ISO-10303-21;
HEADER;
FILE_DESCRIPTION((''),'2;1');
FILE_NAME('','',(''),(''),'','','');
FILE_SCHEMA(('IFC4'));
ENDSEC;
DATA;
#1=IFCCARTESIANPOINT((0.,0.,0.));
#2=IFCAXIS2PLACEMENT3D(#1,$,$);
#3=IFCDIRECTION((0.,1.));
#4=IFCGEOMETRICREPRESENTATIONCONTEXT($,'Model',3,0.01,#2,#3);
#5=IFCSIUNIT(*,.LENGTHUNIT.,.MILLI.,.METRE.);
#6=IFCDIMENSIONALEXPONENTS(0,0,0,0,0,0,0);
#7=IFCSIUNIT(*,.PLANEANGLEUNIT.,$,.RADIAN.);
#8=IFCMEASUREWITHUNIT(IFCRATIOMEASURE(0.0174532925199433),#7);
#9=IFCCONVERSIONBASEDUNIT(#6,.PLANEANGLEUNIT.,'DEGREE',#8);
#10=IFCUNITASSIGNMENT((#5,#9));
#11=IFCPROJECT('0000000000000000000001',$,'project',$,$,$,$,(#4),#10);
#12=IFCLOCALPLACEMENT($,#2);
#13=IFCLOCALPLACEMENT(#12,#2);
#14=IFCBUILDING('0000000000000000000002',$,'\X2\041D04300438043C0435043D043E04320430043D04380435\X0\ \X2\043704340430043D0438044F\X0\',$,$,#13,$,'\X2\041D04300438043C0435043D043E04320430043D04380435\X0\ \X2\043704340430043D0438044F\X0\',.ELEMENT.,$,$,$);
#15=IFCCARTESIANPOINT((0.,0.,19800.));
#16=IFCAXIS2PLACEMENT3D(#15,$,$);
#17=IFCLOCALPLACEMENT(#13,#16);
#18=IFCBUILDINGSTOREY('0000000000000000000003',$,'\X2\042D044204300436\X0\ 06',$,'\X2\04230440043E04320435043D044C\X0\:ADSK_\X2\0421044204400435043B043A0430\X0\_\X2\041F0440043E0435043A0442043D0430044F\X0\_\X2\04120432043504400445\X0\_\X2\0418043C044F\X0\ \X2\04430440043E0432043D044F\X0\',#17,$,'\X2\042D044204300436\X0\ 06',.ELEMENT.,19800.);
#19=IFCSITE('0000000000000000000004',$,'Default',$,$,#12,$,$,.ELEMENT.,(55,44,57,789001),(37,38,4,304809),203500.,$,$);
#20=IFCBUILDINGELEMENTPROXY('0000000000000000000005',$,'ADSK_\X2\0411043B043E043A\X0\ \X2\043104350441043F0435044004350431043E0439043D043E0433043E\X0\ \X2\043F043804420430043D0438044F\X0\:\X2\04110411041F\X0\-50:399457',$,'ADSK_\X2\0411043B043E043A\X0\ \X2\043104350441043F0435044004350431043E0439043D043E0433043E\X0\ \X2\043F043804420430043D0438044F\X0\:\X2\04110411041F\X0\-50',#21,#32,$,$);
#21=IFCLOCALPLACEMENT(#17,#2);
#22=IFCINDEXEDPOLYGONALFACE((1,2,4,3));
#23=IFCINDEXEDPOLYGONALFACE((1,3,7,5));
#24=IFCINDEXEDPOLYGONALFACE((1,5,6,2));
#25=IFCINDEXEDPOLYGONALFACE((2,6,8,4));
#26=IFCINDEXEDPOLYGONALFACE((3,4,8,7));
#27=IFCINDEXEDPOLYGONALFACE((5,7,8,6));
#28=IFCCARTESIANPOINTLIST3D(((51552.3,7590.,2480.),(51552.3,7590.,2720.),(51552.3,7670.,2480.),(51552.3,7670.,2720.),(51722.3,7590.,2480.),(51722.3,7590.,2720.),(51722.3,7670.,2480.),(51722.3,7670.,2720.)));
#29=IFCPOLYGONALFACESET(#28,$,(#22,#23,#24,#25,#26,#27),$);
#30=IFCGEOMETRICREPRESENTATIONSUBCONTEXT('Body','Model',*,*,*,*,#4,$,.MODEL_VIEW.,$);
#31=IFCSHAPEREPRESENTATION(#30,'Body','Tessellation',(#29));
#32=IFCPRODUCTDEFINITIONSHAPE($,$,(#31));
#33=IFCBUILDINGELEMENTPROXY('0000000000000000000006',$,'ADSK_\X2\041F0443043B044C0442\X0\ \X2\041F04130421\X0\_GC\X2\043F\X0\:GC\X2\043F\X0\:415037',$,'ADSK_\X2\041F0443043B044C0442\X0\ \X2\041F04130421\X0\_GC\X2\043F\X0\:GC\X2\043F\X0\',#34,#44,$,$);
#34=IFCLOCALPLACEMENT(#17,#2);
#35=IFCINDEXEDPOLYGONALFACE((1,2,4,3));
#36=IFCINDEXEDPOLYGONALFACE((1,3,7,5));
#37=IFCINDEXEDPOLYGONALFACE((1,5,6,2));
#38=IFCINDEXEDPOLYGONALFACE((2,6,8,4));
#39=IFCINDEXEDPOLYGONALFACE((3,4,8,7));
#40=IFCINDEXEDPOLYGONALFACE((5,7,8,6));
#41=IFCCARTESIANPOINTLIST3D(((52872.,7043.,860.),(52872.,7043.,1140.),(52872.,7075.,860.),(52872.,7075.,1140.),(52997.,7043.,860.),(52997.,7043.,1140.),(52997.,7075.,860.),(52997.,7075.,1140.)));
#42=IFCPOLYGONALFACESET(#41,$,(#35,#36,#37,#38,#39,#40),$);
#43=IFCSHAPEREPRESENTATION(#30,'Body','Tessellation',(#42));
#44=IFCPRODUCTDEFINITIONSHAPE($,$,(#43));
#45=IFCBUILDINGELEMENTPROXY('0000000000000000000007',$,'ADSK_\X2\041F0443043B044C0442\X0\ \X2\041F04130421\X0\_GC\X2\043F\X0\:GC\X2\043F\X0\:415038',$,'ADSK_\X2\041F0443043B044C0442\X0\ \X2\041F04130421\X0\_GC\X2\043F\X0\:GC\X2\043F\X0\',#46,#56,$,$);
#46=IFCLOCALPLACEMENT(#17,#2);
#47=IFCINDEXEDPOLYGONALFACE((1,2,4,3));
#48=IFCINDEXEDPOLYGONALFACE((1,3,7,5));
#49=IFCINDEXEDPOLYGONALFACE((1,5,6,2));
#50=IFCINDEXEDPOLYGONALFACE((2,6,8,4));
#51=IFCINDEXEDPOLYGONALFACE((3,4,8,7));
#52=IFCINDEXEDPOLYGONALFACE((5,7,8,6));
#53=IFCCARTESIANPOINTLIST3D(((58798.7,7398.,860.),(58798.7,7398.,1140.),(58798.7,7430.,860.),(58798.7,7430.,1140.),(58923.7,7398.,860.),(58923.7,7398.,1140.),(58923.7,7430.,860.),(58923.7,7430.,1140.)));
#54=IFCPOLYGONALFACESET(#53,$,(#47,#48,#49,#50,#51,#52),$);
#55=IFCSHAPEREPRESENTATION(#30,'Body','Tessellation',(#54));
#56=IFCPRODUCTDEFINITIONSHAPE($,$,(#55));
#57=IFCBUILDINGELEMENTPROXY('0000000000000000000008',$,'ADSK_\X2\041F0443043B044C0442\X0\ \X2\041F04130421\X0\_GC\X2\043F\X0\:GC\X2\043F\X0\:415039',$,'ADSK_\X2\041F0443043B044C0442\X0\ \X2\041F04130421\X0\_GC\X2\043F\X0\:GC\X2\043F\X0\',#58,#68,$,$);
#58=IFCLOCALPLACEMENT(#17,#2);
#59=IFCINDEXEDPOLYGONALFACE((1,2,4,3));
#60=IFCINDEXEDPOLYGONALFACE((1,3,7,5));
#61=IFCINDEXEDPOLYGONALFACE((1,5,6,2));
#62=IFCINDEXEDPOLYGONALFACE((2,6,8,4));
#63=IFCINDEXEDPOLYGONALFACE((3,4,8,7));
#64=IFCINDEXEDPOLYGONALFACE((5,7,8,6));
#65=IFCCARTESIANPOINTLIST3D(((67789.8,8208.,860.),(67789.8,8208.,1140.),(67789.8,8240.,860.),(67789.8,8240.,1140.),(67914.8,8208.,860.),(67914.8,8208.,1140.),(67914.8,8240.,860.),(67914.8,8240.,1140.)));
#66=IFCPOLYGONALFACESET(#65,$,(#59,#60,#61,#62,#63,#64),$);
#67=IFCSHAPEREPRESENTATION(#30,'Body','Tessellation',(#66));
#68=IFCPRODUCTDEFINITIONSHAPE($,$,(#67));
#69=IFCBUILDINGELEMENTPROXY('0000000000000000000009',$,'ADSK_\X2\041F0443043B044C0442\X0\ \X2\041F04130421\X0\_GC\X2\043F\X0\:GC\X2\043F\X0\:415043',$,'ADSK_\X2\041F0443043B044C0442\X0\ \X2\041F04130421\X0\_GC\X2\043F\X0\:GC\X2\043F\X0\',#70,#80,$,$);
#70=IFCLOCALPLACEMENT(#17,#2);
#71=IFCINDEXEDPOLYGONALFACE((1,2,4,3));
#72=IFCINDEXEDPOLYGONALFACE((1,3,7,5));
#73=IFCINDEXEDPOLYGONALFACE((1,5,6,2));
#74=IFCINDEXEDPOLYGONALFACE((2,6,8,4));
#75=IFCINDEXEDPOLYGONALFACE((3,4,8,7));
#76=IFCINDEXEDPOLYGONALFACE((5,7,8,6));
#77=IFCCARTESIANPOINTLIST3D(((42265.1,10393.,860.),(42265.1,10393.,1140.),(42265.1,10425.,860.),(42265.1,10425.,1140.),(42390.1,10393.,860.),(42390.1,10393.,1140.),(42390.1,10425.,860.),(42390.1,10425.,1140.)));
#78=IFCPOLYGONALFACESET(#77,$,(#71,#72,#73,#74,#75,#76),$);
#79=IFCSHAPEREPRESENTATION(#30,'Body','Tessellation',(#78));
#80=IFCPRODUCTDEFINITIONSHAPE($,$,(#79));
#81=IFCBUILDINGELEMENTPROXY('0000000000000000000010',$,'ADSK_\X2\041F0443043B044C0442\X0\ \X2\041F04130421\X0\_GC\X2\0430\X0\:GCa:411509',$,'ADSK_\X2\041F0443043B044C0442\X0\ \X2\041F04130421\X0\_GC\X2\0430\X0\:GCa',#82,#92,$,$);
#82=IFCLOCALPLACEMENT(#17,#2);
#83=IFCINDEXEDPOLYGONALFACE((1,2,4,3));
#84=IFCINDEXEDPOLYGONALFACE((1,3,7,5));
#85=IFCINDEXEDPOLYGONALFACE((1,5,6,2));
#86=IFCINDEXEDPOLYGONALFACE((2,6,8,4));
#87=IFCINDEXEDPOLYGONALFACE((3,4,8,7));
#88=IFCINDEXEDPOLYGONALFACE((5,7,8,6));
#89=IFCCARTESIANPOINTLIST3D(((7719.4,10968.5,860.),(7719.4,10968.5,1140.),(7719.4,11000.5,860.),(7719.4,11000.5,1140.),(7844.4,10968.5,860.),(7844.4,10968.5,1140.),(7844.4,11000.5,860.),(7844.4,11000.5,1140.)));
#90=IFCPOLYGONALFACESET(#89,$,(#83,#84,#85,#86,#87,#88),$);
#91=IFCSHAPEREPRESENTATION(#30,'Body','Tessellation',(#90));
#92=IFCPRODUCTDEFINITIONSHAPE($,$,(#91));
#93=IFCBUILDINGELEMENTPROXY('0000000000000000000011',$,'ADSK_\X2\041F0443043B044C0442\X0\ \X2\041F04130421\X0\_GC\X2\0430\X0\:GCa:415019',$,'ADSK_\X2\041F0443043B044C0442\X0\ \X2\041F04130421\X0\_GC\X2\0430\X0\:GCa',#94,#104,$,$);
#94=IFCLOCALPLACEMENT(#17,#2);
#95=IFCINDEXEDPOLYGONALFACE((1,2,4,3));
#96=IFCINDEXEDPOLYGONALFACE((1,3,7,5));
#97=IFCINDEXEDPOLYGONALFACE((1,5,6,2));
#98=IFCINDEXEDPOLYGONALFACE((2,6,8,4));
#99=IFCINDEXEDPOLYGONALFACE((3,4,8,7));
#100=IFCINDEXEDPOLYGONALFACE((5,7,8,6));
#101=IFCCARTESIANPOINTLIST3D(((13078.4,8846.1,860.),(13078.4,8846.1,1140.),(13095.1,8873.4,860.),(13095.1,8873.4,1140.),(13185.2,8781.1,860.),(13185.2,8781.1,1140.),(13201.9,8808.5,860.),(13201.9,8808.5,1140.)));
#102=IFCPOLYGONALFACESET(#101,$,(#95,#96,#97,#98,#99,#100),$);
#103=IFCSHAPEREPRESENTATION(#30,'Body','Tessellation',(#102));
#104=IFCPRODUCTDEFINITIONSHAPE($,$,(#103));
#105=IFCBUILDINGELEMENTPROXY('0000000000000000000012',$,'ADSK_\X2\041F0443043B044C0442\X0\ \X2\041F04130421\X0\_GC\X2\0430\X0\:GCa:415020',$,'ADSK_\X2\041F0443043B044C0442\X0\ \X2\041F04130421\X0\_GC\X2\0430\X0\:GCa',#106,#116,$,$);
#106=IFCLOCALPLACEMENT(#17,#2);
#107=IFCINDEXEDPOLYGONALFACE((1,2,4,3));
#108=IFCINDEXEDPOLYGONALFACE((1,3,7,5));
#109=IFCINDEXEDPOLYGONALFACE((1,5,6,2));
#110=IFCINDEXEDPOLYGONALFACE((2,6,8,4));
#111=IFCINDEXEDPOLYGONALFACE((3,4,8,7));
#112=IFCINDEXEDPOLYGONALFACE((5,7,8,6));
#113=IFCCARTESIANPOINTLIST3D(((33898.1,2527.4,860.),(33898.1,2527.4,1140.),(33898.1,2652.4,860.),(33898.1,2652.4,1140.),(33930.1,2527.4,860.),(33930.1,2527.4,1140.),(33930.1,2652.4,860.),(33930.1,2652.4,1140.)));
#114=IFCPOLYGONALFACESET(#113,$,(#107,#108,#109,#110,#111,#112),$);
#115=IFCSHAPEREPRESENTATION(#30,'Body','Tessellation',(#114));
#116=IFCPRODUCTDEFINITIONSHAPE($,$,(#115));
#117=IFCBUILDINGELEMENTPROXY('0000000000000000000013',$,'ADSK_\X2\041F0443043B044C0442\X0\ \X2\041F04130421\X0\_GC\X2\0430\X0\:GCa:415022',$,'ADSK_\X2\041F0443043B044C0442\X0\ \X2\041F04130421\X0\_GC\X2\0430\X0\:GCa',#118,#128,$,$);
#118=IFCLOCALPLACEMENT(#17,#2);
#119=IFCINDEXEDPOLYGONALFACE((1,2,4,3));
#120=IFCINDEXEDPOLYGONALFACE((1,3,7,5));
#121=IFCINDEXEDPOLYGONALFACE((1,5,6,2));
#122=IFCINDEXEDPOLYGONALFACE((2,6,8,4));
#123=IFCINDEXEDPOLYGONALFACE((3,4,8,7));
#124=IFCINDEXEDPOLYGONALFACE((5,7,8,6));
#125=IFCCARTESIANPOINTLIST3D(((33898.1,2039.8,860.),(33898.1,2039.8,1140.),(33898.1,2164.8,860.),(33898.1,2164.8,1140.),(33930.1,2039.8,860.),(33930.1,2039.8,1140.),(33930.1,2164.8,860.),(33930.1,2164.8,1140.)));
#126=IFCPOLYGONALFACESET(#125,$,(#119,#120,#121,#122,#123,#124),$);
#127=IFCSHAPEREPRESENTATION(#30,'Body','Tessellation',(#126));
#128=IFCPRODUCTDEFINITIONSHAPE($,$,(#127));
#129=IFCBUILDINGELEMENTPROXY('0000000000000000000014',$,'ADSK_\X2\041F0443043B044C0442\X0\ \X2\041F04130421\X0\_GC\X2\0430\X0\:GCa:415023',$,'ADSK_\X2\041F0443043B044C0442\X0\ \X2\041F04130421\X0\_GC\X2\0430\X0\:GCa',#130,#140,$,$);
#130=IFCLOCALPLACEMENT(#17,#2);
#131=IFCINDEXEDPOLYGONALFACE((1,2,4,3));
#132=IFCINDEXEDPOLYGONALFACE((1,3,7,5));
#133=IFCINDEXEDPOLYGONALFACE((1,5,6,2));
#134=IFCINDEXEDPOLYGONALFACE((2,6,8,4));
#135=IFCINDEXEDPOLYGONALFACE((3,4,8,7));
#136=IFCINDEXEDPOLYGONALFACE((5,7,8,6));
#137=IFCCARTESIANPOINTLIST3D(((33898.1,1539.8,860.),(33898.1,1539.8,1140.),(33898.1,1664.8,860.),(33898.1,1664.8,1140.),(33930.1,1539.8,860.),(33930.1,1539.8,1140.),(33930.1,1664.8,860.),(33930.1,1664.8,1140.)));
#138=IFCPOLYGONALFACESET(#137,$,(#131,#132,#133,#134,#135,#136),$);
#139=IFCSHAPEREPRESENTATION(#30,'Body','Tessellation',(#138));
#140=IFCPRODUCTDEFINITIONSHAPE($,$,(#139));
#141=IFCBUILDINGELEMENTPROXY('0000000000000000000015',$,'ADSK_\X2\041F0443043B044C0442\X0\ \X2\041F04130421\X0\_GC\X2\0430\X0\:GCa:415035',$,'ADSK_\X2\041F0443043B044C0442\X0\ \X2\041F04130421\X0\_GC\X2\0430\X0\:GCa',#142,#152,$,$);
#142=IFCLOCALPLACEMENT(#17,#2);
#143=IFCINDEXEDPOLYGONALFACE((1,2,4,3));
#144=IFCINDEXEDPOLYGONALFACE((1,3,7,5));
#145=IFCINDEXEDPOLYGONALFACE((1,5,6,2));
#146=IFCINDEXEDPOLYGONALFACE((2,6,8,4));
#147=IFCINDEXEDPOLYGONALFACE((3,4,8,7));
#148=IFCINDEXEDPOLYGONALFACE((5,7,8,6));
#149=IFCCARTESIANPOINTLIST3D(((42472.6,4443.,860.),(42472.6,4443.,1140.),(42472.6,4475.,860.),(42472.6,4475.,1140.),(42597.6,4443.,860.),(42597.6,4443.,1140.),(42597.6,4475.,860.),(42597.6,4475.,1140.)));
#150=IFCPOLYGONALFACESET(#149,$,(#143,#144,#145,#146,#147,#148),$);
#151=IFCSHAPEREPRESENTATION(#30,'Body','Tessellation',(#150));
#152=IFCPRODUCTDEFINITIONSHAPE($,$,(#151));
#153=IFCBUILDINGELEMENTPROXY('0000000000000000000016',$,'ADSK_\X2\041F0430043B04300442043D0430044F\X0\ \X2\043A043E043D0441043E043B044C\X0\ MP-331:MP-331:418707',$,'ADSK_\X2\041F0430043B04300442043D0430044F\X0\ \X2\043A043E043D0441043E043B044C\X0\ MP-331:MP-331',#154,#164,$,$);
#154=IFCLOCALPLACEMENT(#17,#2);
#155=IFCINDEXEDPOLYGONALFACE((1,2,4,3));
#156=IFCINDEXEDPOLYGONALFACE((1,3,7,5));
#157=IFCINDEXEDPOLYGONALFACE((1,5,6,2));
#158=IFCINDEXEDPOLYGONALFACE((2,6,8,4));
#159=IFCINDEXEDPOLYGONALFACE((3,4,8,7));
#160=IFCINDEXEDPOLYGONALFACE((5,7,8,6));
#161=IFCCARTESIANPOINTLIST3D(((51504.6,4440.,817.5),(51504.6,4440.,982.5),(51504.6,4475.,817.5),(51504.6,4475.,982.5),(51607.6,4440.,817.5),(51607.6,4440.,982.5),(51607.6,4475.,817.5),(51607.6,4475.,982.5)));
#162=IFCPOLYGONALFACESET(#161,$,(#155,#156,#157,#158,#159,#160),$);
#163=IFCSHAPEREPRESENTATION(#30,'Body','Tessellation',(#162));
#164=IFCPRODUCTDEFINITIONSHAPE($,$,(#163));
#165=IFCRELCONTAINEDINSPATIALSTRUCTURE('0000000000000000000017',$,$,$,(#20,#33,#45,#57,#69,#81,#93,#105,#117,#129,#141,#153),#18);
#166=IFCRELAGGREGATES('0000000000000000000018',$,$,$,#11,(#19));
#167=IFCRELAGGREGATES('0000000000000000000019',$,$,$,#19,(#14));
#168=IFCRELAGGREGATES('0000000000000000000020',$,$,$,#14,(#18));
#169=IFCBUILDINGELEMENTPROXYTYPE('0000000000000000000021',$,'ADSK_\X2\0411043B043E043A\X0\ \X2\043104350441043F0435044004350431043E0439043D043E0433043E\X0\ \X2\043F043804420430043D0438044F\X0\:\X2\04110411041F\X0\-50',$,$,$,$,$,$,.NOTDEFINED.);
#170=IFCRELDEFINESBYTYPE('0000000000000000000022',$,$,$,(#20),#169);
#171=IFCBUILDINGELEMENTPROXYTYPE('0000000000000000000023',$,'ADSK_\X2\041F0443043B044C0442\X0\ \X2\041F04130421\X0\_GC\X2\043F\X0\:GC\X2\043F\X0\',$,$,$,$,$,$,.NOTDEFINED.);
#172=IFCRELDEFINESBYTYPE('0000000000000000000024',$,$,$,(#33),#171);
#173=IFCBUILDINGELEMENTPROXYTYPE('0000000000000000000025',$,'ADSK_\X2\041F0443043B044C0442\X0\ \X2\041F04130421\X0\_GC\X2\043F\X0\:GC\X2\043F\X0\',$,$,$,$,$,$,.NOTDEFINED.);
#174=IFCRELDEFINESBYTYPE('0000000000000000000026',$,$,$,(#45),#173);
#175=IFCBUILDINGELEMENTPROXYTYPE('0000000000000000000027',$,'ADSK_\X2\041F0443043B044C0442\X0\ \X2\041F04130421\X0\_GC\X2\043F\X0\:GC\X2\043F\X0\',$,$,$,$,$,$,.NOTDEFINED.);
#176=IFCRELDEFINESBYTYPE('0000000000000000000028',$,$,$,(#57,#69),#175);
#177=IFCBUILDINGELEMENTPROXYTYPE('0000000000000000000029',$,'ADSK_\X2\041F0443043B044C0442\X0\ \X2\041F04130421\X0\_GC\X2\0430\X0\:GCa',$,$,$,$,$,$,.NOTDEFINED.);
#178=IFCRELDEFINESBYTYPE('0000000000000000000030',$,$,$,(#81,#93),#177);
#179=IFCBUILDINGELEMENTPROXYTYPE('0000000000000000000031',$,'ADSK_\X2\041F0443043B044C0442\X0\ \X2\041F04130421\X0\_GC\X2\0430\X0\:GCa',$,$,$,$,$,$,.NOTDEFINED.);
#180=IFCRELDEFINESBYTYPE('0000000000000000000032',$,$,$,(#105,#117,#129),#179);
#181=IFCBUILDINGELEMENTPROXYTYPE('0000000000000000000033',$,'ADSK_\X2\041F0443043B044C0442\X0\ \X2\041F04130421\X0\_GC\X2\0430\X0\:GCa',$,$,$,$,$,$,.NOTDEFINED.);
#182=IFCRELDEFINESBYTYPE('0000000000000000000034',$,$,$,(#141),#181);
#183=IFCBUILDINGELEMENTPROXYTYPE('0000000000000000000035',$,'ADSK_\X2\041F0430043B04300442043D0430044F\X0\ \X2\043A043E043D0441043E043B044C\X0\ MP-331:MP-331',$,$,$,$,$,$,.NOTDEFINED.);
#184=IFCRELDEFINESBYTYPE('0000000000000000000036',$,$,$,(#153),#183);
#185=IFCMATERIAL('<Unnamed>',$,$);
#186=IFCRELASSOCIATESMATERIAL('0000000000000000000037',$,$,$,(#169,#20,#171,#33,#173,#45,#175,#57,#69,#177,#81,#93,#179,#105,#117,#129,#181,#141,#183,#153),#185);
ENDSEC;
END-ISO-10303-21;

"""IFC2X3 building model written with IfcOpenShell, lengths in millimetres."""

from ifc_helpers import new_model, entity, si_unit, converted_unit, direction, frame, origin, origin_2d_with_axis, place, context, subcontext, project, spatial, rectangle, extrude, source, transform, mapped, material, type_object, type_shapes, element, save


model = new_model("IFC2X3")

# Units and contexts
model_context = context("Model", 3, precision=0.01, world=origin(), true_north=direction((0.0, 1.0)))
body_context = subcontext(model_context, "Body", "Model", "MODEL_VIEW")
ifc_project = project(units=[si_unit("LENGTHUNIT", "METRE", prefix="MILLI"), converted_unit("PLANEANGLEUNIT", "DEGREE", entity("IfcRatioMeasure", 0.0174532925199433), si_unit("PLANEANGLEUNIT", "RADIAN"), dimensions=[0, 0, 0, 0, 0, 0, 0])], contexts=[model_context])

# Site, building, storey
site_placement = place(None, origin())
site = spatial("IfcSite", under=ifc_project, at=site_placement, Name="Default", CompositionType="ELEMENT", RefLatitude=(55, 44, 57, 789001), RefLongitude=(37, 38, 4, 304809), RefElevation=203500.0)
building_placement = place(site_placement, origin())
building = spatial("IfcBuilding", under=site, at=building_placement, Name="Наименование здания", LongName="Наименование здания", CompositionType="ELEMENT")
storey_placement = place(building_placement, frame((0.0, 0.0, 19800.0)))
storey = spatial("IfcBuildingStorey", under=building, at=storey_placement, Name="Этаж 06", ObjectType="Уровень:ADSK_Стрелка_Проектная_Вверх_Имя уровня", LongName="Этаж 06", CompositionType="ELEMENT", Elevation=19800.0)

# Building element proxies
ifc_material_1 = material(Name="<Unnamed>")
building_element_proxy_type_1 = type_object("IfcBuildingElementProxyType", Name="ADSK_Блок бесперебойного питания:ББП-50", PredefinedType="NOTDEFINED", material=ifc_material_1)
shared_shape_1 = source(origin(), body_context, "Body", "SweptSolid", [
    extrude(rectangle(XDim=170.0, YDim=80.0, at=origin_2d_with_axis()), frame((0.0, -8.0, -120.0), z_axis=(0.0, 0.0, 1.0), x_axis=(-1.0, 0.0, 0.0)), (0.0, 0.0, 1.0), 240.0),
])
type_shapes(building_element_proxy_type_1, [shared_shape_1])
for number, where, z_axis, x_axis, name in (
    (1, (51637.3, 7622.0, 2600.0), (0.0, 0.0, 1.0), (-1.0, 0.0, 0.0), "ADSK_Блок бесперебойного питания:ББП-50:399457"),
):
    element("IfcBuildingElementProxy", number, at=place(storey_placement, frame(where, z_axis=z_axis, x_axis=x_axis)), inside=storey, type_object=building_element_proxy_type_1, material=ifc_material_1, Name=name, ObjectType="ADSK_Блок бесперебойного питания:ББП-50", context=body_context, shape_type="MappedRepresentation", body=[
        mapped(shared_shape_1, transform((0.0, 0.0, 0.0), scale=1.0)),
    ])
building_element_proxy_type_2 = type_object("IfcBuildingElementProxyType", Name="ADSK_Пульт ПГС_GCп:GCп", PredefinedType="NOTDEFINED", material=ifc_material_1)
shared_shape_2 = source(origin(), body_context, "Body", "SweptSolid", [
    extrude(rectangle(XDim=125.0, YDim=32.0, at=origin_2d_with_axis()), frame((0.0, 16.0, -140.0), z_axis=(0.0, 0.0, 1.0), x_axis=(-1.0, 0.0, 0.0)), (0.0, 0.0, 1.0), 280.0),
])
type_shapes(building_element_proxy_type_2, [shared_shape_2])
proxy_1_placement = place(storey_placement, frame((52934.5, 7043.0, 1000.0)))
element("IfcBuildingElementProxy", 2, at=proxy_1_placement, inside=storey, type_object=building_element_proxy_type_2, material=ifc_material_1, Name="ADSK_Пульт ПГС_GCп:GCп:415037", ObjectType="ADSK_Пульт ПГС_GCп:GCп", context=body_context, shape_type="MappedRepresentation", body=[
    mapped(shared_shape_2, transform((0.0, 0.0, 0.0), scale=1.0)),
])
building_element_proxy_type_3 = type_object("IfcBuildingElementProxyType", Name="ADSK_Пульт ПГС_GCп:GCп", PredefinedType="NOTDEFINED", material=ifc_material_1)
type_shapes(building_element_proxy_type_3, [shared_shape_2])
proxy_2_placement = place(storey_placement, frame((58861.2, 7398.0, 1000.0)))
element("IfcBuildingElementProxy", 3, at=proxy_2_placement, inside=storey, type_object=building_element_proxy_type_3, material=ifc_material_1, Name="ADSK_Пульт ПГС_GCп:GCп:415038", ObjectType="ADSK_Пульт ПГС_GCп:GCп", context=body_context, shape_type="MappedRepresentation", body=[
    mapped(shared_shape_2, transform((0.0, 0.0, 0.0), scale=1.0)),
])
building_element_proxy_type_4 = type_object("IfcBuildingElementProxyType", Name="ADSK_Пульт ПГС_GCп:GCп", PredefinedType="NOTDEFINED", material=ifc_material_1)
type_shapes(building_element_proxy_type_4, [shared_shape_2])
for number, where, name in (
    (4, (67852.3, 8208.0, 1000.0), "ADSK_Пульт ПГС_GCп:GCп:415039"),
    (5, (42327.6, 10393.0, 1000.0), "ADSK_Пульт ПГС_GCп:GCп:415043"),
):
    element("IfcBuildingElementProxy", number, at=place(storey_placement, frame(where)), inside=storey, type_object=building_element_proxy_type_4, material=ifc_material_1, Name=name, ObjectType="ADSK_Пульт ПГС_GCп:GCп", context=body_context, shape_type="MappedRepresentation", body=[
        mapped(shared_shape_2, transform((0.0, 0.0, 0.0), scale=1.0)),
    ])
building_element_proxy_type_5 = type_object("IfcBuildingElementProxyType", Name="ADSK_Пульт ПГС_GCа:GCa", PredefinedType="NOTDEFINED", material=ifc_material_1)
shared_shape_3 = source(origin(), body_context, "Body", "SweptSolid", [
    extrude(rectangle(XDim=125.0, YDim=32.0, at=origin_2d_with_axis()), frame((0.0, 16.0, -140.0), z_axis=(0.0, 0.0, 1.0), x_axis=(-1.0, 0.0, 0.0)), (0.0, 0.0, 1.0), 280.0),
])
type_shapes(building_element_proxy_type_5, [shared_shape_3])
for number, where, z_axis, x_axis, name in (
    (6, (7781.9, 11000.5, 1000.0), (0.0, 0.0, 1.0), (-1.0, 0.0, 0.0), "ADSK_Пульт ПГС_GCа:GCa:411509"),
    (7, (13148.5, 8840.9, 1000.0), (0.0, 0.0, 1.0), (-0.854449, 0.519535, 0.0), "ADSK_Пульт ПГС_GCа:GCa:415019"),
):
    element("IfcBuildingElementProxy", number, at=place(storey_placement, frame(where, z_axis=z_axis, x_axis=x_axis)), inside=storey, type_object=building_element_proxy_type_5, material=ifc_material_1, Name=name, ObjectType="ADSK_Пульт ПГС_GCа:GCa", context=body_context, shape_type="MappedRepresentation", body=[
        mapped(shared_shape_3, transform((0.0, 0.0, 0.0), scale=1.0)),
    ])
building_element_proxy_type_6 = type_object("IfcBuildingElementProxyType", Name="ADSK_Пульт ПГС_GCа:GCa", PredefinedType="NOTDEFINED", material=ifc_material_1)
type_shapes(building_element_proxy_type_6, [shared_shape_3])
for number, where, z_axis, x_axis, name in (
    (8, (33898.1, 2589.9, 1000.0), (0.0, 0.0, 1.0), (0.0, -1.0, 0.0), "ADSK_Пульт ПГС_GCа:GCa:415020"),
    (9, (33898.1, 2102.3, 1000.0), (0.0, 0.0, 1.0), (0.0, -1.0, 0.0), "ADSK_Пульт ПГС_GCа:GCa:415022"),
    (10, (33898.1, 1602.3, 1000.0), (0.0, 0.0, 1.0), (0.0, -1.0, 0.0), "ADSK_Пульт ПГС_GCа:GCa:415023"),
):
    element("IfcBuildingElementProxy", number, at=place(storey_placement, frame(where, z_axis=z_axis, x_axis=x_axis)), inside=storey, type_object=building_element_proxy_type_6, material=ifc_material_1, Name=name, ObjectType="ADSK_Пульт ПГС_GCа:GCa", context=body_context, shape_type="MappedRepresentation", body=[
        mapped(shared_shape_3, transform((0.0, 0.0, 0.0), scale=1.0)),
    ])
building_element_proxy_type_7 = type_object("IfcBuildingElementProxyType", Name="ADSK_Пульт ПГС_GCа:GCa", PredefinedType="NOTDEFINED", material=ifc_material_1)
type_shapes(building_element_proxy_type_7, [shared_shape_3])
proxy_3_placement = place(storey_placement, frame((42535.1, 4443.0, 1000.0)))
element("IfcBuildingElementProxy", 11, at=proxy_3_placement, inside=storey, type_object=building_element_proxy_type_7, material=ifc_material_1, Name="ADSK_Пульт ПГС_GCа:GCa:415035", ObjectType="ADSK_Пульт ПГС_GCа:GCa", context=body_context, shape_type="MappedRepresentation", body=[
    mapped(shared_shape_3, transform((0.0, 0.0, 0.0), scale=1.0)),
])
building_element_proxy_type_8 = type_object("IfcBuildingElementProxyType", Name="ADSK_Палатная консоль MP-331:MP-331", PredefinedType="NOTDEFINED", material=ifc_material_1)
shared_shape_4 = source(origin(), body_context, "Body", "SweptSolid", [
    extrude(rectangle(XDim=103.0, YDim=35.0, at=origin_2d_with_axis()), frame((0.0, 14.5, -82.5), z_axis=(0.0, 0.0, 1.0), x_axis=(-1.0, 0.0, 0.0)), (0.0, 0.0, 1.0), 165.0),
])
type_shapes(building_element_proxy_type_8, [shared_shape_4])
proxy_4_placement = place(storey_placement, frame((51556.1, 4443.0, 900.0)))
element("IfcBuildingElementProxy", 12, at=proxy_4_placement, inside=storey, type_object=building_element_proxy_type_8, material=ifc_material_1, Name="ADSK_Палатная консоль MP-331:MP-331:418707", ObjectType="ADSK_Палатная консоль MP-331:MP-331", context=body_context, shape_type="MappedRepresentation", body=[
    mapped(shared_shape_4, transform((0.0, 0.0, 0.0), scale=1.0)),
])

save(model, "model.ifc")
